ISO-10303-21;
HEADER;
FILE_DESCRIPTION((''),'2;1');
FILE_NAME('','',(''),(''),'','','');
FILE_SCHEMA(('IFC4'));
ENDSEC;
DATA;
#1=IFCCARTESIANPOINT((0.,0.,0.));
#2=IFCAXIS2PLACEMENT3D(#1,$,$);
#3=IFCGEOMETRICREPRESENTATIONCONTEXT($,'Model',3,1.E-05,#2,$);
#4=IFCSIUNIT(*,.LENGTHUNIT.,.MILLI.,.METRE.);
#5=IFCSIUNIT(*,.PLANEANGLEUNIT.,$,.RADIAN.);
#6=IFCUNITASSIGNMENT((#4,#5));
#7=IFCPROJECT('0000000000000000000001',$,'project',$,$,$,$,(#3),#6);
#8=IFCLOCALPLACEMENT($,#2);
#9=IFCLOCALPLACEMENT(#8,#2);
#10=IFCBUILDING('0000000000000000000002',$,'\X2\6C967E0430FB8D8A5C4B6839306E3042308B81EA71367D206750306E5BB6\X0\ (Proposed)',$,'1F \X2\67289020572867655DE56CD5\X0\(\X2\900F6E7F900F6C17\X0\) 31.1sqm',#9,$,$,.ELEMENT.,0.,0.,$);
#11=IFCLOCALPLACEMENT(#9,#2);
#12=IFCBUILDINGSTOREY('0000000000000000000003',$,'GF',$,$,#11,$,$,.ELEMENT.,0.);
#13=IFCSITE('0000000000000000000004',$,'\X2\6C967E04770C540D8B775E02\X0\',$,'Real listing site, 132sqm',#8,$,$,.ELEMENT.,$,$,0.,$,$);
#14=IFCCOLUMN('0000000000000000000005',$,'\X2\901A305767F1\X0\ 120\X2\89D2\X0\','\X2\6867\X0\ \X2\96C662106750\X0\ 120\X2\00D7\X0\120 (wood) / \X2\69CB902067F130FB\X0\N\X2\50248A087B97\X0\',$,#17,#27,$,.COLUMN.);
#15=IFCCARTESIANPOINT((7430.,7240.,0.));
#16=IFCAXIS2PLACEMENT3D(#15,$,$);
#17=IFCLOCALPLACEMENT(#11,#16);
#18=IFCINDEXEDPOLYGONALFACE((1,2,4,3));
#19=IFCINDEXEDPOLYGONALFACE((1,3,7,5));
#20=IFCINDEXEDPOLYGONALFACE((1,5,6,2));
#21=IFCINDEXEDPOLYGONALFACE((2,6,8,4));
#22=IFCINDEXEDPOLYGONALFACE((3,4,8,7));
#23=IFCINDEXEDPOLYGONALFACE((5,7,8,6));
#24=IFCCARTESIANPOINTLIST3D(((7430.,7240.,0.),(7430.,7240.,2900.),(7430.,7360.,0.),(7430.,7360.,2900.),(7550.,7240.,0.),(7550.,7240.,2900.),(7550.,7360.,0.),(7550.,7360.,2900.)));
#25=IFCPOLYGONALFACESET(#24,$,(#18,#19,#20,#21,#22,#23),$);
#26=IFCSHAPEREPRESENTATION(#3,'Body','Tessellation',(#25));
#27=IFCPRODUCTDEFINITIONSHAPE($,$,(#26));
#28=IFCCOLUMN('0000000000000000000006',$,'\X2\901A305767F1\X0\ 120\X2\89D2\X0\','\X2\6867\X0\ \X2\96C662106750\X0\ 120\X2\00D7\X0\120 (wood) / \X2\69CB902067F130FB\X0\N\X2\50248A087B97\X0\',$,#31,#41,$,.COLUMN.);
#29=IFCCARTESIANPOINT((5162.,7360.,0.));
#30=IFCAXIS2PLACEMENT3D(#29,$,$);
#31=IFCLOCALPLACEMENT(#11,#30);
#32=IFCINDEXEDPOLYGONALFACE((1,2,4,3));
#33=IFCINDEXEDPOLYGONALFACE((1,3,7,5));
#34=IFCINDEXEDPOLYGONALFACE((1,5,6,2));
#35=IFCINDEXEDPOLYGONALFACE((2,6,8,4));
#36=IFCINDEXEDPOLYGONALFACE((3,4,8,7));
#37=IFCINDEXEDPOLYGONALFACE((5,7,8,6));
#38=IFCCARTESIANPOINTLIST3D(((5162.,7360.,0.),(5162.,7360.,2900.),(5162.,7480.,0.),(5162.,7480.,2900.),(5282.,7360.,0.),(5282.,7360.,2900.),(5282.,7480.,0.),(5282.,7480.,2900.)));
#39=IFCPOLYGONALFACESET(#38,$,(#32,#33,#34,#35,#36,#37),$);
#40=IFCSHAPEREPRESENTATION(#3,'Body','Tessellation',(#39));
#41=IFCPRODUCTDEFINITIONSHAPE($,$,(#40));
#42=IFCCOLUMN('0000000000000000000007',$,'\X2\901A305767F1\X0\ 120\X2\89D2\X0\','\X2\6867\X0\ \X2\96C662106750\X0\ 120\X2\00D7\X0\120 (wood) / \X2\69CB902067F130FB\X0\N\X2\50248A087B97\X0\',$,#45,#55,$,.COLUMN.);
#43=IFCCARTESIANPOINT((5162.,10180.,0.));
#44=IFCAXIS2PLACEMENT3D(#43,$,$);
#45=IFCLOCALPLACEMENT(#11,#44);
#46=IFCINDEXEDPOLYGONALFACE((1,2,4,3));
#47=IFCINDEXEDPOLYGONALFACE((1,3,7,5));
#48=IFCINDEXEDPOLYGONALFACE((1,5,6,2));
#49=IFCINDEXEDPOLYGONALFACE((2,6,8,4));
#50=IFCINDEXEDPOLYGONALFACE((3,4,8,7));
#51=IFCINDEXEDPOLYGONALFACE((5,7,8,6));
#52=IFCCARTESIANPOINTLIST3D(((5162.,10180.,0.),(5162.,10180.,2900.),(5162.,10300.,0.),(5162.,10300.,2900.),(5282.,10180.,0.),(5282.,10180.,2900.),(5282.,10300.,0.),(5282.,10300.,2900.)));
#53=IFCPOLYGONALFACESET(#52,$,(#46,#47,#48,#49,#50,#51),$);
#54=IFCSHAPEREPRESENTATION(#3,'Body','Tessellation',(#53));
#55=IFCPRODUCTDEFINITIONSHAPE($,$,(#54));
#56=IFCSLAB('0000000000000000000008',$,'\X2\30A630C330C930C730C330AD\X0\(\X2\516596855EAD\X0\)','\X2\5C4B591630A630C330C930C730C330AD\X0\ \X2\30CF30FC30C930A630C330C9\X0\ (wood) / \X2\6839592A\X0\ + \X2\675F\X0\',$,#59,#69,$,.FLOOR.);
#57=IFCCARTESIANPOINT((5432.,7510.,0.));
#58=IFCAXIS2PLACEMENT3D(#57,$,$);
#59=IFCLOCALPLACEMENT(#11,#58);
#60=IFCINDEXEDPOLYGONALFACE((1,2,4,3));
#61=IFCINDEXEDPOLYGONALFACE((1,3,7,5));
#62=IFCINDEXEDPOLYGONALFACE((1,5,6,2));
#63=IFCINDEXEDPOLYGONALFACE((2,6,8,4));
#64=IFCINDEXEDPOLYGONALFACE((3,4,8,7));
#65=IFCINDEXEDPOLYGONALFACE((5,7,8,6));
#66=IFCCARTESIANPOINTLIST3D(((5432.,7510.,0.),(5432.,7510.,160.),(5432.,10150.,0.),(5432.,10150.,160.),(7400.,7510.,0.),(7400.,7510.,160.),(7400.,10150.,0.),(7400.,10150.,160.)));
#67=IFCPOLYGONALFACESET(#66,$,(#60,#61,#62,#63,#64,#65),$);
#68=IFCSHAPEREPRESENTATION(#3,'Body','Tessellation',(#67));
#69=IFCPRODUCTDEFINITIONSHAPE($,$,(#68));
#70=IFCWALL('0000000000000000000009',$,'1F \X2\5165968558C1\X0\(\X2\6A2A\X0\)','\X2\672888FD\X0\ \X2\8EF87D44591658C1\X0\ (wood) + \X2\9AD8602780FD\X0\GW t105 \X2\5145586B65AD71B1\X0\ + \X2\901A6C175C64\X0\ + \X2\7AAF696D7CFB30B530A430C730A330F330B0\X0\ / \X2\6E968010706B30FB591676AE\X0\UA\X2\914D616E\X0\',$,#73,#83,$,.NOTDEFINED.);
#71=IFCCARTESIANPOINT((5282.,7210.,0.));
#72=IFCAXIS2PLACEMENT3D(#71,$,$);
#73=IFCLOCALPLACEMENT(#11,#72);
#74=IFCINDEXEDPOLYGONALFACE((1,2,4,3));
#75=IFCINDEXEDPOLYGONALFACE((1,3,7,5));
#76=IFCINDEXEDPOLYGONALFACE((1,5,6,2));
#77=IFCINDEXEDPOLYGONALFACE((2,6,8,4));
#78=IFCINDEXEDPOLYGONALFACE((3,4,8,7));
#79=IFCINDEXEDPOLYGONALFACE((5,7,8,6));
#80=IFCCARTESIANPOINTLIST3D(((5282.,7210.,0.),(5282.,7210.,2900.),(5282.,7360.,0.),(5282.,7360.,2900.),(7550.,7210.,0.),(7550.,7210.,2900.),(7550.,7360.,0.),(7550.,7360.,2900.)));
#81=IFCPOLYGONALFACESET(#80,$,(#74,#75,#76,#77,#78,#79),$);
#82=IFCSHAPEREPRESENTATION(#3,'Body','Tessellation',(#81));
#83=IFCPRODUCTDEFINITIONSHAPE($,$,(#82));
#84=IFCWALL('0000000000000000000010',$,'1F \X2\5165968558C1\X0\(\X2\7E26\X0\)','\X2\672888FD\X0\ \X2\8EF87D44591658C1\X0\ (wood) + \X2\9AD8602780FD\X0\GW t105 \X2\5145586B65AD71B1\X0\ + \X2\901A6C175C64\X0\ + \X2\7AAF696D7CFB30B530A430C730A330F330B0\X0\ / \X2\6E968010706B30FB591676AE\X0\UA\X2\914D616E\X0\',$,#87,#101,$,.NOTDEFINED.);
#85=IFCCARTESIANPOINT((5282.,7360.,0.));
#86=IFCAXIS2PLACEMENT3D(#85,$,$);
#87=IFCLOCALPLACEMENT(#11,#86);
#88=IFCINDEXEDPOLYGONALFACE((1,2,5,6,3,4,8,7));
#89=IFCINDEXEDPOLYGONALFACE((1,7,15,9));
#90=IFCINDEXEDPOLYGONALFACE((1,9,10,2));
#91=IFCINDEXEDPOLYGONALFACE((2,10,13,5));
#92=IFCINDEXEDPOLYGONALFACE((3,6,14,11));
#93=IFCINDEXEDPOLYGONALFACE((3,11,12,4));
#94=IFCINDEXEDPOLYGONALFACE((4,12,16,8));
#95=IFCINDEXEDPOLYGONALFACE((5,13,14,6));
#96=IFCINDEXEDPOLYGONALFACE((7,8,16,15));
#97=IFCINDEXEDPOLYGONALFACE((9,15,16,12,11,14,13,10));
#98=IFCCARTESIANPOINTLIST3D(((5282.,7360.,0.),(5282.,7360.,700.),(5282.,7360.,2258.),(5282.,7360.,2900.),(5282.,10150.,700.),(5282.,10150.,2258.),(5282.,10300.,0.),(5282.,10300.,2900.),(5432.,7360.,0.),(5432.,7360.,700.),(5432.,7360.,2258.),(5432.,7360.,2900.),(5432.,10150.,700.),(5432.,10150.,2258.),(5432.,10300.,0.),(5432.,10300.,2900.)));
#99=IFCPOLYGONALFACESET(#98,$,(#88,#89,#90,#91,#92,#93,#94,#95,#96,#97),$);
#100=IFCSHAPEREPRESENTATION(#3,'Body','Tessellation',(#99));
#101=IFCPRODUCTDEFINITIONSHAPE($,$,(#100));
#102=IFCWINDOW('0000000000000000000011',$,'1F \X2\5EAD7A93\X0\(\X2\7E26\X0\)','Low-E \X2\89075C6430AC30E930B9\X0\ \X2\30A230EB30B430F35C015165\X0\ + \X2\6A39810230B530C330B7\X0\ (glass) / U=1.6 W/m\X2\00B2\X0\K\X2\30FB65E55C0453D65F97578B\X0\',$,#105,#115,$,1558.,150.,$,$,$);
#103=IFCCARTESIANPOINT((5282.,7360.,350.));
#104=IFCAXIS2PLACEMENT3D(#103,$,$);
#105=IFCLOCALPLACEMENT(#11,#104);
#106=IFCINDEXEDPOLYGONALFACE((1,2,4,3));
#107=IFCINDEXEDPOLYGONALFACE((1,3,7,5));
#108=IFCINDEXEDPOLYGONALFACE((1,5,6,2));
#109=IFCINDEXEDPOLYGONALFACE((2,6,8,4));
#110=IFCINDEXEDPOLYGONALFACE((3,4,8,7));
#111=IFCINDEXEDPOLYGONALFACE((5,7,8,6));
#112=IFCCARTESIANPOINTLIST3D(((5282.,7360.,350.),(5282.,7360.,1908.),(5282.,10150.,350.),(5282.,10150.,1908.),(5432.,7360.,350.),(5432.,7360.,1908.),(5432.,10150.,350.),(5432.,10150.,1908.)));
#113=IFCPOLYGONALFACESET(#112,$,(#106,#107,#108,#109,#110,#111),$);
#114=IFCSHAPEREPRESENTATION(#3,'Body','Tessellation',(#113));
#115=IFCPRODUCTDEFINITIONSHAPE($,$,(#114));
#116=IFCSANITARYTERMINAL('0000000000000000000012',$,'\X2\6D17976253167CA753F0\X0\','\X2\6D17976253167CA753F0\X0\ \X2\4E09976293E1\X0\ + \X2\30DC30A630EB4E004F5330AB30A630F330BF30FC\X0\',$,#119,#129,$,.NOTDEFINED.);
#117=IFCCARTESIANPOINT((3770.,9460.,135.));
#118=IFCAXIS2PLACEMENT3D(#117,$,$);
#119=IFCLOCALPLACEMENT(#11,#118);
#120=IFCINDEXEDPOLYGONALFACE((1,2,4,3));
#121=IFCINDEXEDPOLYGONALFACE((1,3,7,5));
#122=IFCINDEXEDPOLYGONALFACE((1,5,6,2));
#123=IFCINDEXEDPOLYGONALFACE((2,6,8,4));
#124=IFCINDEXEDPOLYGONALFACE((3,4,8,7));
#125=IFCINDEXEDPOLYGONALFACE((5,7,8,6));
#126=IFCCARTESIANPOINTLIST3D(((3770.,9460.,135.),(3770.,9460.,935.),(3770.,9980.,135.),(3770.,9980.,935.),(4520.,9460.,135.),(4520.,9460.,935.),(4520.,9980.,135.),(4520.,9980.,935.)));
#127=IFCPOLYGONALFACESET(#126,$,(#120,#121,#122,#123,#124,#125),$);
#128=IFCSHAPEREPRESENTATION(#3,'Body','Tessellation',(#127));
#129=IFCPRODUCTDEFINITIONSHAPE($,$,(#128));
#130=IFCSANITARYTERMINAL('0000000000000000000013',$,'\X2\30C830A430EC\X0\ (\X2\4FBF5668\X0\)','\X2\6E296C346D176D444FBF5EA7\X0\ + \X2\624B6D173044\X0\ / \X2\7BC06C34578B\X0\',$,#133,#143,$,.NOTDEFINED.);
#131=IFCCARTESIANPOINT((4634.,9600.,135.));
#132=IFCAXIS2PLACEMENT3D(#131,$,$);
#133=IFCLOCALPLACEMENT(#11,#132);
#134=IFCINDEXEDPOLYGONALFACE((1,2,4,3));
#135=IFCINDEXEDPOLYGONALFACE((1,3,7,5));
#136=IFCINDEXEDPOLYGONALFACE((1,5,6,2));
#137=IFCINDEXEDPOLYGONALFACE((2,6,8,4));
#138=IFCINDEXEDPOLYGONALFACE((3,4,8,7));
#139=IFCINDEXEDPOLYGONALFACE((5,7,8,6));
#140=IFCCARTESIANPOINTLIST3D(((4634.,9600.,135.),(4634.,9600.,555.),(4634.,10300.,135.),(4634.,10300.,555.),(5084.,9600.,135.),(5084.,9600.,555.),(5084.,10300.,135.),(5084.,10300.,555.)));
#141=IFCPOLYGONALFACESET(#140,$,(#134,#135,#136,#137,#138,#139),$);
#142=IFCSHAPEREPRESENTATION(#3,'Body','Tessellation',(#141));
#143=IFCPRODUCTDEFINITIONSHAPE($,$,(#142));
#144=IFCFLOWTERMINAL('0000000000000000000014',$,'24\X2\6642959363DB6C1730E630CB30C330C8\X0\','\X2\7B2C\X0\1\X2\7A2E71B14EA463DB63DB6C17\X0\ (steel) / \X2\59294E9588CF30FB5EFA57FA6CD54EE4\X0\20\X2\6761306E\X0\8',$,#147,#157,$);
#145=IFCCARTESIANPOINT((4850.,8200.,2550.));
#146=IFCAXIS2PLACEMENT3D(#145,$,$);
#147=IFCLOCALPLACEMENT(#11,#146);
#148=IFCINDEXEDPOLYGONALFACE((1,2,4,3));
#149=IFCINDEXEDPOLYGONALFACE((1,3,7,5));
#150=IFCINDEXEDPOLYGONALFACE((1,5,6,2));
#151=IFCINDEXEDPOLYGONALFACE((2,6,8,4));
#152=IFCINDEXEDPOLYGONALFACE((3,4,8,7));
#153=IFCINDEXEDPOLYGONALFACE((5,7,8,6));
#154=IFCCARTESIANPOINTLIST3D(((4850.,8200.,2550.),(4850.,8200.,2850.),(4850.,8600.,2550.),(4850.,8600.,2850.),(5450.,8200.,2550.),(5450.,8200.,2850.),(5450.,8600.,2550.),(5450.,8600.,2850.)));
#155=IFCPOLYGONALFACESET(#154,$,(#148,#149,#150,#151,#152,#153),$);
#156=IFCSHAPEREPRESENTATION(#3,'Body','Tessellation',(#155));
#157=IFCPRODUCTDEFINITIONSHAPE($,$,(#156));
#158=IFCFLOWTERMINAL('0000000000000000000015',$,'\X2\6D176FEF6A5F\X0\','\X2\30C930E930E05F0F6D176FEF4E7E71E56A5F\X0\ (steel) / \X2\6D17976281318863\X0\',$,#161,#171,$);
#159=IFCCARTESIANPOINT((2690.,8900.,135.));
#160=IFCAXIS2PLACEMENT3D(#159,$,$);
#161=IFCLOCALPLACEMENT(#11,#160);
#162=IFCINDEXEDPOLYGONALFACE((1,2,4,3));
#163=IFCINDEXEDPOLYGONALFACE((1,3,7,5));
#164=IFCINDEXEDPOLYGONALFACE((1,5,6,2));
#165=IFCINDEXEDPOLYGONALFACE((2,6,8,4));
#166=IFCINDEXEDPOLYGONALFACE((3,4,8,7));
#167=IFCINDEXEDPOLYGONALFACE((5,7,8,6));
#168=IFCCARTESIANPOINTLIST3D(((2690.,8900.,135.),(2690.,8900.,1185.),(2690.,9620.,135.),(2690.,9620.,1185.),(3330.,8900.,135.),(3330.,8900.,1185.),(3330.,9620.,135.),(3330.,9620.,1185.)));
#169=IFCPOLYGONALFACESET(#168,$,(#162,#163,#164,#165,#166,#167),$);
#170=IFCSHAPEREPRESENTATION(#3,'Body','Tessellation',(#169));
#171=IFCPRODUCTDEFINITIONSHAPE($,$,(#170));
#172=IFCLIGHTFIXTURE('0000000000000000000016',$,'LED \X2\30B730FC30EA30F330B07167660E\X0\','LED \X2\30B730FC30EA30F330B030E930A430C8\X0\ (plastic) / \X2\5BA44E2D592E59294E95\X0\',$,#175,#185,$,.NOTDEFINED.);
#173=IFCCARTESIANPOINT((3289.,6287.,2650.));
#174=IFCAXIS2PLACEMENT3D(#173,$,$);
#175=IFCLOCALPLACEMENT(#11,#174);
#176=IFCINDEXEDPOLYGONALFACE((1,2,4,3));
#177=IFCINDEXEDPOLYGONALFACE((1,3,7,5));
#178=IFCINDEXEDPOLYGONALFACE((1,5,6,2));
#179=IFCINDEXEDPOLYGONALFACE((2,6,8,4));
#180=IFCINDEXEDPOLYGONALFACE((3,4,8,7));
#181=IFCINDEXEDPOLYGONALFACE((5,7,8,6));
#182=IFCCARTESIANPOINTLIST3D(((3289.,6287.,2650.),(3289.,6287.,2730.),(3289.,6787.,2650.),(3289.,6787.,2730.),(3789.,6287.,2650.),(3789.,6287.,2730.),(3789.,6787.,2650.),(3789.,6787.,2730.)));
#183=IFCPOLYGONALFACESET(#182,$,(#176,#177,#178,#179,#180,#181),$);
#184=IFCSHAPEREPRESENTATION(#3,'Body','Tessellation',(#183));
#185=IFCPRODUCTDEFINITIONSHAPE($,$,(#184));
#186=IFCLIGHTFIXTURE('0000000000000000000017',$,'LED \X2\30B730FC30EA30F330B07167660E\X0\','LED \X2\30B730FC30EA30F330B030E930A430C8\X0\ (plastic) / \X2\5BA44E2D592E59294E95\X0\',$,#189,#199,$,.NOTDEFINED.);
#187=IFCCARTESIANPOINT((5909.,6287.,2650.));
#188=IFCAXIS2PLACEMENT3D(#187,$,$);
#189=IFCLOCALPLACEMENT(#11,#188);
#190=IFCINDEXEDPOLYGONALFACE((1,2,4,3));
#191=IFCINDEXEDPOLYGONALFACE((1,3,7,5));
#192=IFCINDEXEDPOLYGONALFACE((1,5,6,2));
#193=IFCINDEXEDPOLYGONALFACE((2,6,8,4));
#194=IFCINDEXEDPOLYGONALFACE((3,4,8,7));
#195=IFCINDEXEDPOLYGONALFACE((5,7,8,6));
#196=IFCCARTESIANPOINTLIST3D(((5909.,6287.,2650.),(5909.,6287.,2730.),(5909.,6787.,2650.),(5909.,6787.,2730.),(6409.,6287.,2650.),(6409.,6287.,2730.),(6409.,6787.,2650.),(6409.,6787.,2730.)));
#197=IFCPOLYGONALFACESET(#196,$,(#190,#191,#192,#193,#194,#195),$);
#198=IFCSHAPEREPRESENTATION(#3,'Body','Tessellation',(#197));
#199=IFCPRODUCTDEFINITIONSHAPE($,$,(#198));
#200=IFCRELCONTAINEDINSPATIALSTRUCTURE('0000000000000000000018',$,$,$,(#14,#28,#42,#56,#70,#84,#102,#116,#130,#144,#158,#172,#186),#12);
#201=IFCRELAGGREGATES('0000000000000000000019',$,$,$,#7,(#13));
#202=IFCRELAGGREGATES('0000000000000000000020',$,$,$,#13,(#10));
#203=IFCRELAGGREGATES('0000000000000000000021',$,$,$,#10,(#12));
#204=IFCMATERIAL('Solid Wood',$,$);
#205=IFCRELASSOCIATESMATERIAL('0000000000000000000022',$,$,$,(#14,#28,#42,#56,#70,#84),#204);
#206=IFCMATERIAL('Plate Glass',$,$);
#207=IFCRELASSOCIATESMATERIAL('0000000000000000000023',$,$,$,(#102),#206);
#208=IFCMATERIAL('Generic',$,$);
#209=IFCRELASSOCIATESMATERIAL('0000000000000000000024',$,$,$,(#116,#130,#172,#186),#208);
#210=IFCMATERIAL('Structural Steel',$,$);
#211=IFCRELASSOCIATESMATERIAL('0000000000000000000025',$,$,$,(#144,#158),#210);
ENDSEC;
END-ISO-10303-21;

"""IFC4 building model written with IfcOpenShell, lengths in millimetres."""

from ifc_helpers import new_model, si_unit, frame, frame_2d, origin, place, context, project, spatial, rectangle, extrude, material, element, fill, save


model = new_model("IFC4")

# Units and contexts
model_context = context("Model", 3, precision=1e-05, world=origin())
ifc_project = project(units=[si_unit("LENGTHUNIT", "METRE", prefix="MILLI"), si_unit("PLANEANGLEUNIT", "RADIAN")], contexts=[model_context])

# Site, building, storey
site_placement = place(None, origin())
site = spatial("IfcSite", under=ifc_project, at=site_placement, Name="沖縄県名護市", ObjectType="Real listing site, 132sqm", CompositionType="ELEMENT", RefElevation=0.0)
building_placement = place(site_placement, origin())
building = spatial("IfcBuilding", under=site, at=building_placement, Name="沖縄・越屋根のある自然素材の家 (Proposed)", ObjectType="1F 木造在来工法(透湿透気) 31.1sqm", CompositionType="ELEMENT", ElevationOfRefHeight=0.0, ElevationOfTerrain=0.0)
storey_placement = place(building_placement, origin())
storey = spatial("IfcBuildingStorey", under=building, at=storey_placement, Name="GF", CompositionType="ELEMENT", Elevation=0.0)

# Columns
ifc_material_1 = material(Name="Solid Wood")
column_1_placement = place(storey_placement, frame((7430.0, 7240.0, 0.0)))
element("IfcColumn", 1, at=column_1_placement, inside=storey, material=ifc_material_1, Name="通し柱 120角", Description="桧 集成材 120×120 (wood) / 構造柱・N値計算", PredefinedType="COLUMN", context=model_context, shape_type="SweptSolid", body=[
    extrude(rectangle(XDim=120.0, YDim=120.0, at=frame_2d((60.0, 60.0))), frame((7430.0, 7240.0, 0.0)), (0.0, 0.0, 1.0), 2900.0),
])
column_2_placement = place(storey_placement, frame((5162.0, 7360.0, 0.0)))
element("IfcColumn", 2, at=column_2_placement, inside=storey, material=ifc_material_1, Name="通し柱 120角", Description="桧 集成材 120×120 (wood) / 構造柱・N値計算", PredefinedType="COLUMN", context=model_context, shape_type="SweptSolid", body=[
    extrude(rectangle(XDim=120.0, YDim=120.0, at=frame_2d((60.0, 60.0))), frame((5162.0, 7360.0, 0.0)), (0.0, 0.0, 1.0), 2900.0),
])
column_3_placement = place(storey_placement, frame((5162.0, 10180.0, 0.0)))
element("IfcColumn", 3, at=column_3_placement, inside=storey, material=ifc_material_1, Name="通し柱 120角", Description="桧 集成材 120×120 (wood) / 構造柱・N値計算", PredefinedType="COLUMN", context=model_context, shape_type="SweptSolid", body=[
    extrude(rectangle(XDim=120.0, YDim=120.0, at=frame_2d((60.0, 60.0))), frame((5162.0, 10180.0, 0.0)), (0.0, 0.0, 1.0), 2900.0),
])

# Slab
slab_placement = place(storey_placement, frame((5432.0, 7510.0, 0.0)))
element("IfcSlab", 4, at=slab_placement, inside=storey, material=ifc_material_1, Name="ウッドデッキ(入隅庭)", Description="屋外ウッドデッキ ハードウッド (wood) / 根太 + 束", PredefinedType="FLOOR", context=model_context, shape_type="SweptSolid", body=[
    extrude(rectangle(XDim=1968.0, YDim=2640.0, at=frame_2d((984.0, 1320.0))), frame((5432.0, 7510.0, 0.0)), (0.0, 0.0, 1.0), 160.0),
])

# Wall
wall_1_placement = place(storey_placement, frame((5282.0, 7210.0, 0.0)))
element("IfcWall", 5, at=wall_1_placement, inside=storey, material=ifc_material_1, Name="1F 入隅壁(横)", Description="木製 軸組外壁 (wood) + 高性能GW t105 充填断熱 + 通気層 + 窯業系サイディング / 準耐火・外皮UA配慮", PredefinedType="NOTDEFINED", context=model_context, shape_type="SweptSolid", body=[
    extrude(rectangle(XDim=2268.0, YDim=150.0, at=frame_2d((1134.0, 75.0))), frame((5282.0, 7210.0, 0.0)), (0.0, 0.0, 1.0), 2900.0),
])

# Wall, opening, window
wall_2_placement = place(storey_placement, frame((5282.0, 7360.0, 0.0)))
wall_2 = element("IfcWall", 6, at=wall_2_placement, inside=storey, material=ifc_material_1, Name="1F 入隅壁(縦)", Description="木製 軸組外壁 (wood) + 高性能GW t105 充填断熱 + 通気層 + 窯業系サイディング / 準耐火・外皮UA配慮", PredefinedType="NOTDEFINED", context=model_context, shape_type="SweptSolid", body=[
    extrude(rectangle(XDim=150.0, YDim=2940.0, at=frame_2d((75.0, 1470.0))), frame((5282.0, 7360.0, 0.0)), (0.0, 0.0, 1.0), 2900.0),
])
opening_placement = place(storey_placement, frame((5282.0, 7360.0, 350.0)))
opening = element("IfcOpeningElement", 7, at=opening_placement, cuts=wall_2, PredefinedType="NOTDEFINED", context=model_context, shape_type="SweptSolid", body=[
    extrude(rectangle(XDim=150.0, YDim=2790.0, at=frame_2d((75.0, 1395.0))), frame((5282.0, 7360.0, 350.0)), (0.0, 0.0, 1.0), 1558.0),
])
ifc_material_2 = material(Name="Plate Glass")
window_placement = place(storey_placement, frame((5282.0, 7360.0, 350.0)))
window = element("IfcWindow", 8, at=window_placement, inside=storey, material=ifc_material_2, Name="1F 庭窓(縦)", Description="Low-E 複層ガラス アルゴン封入 + 樹脂サッシ (glass) / U=1.6 W/m²K・日射取得型", OverallHeight=1558.0, OverallWidth=150.0, context=model_context, shape_type="SweptSolid", body=[
    extrude(rectangle(XDim=150.0, YDim=2790.0, at=frame_2d((75.0, 1395.0))), frame((5282.0, 7360.0, 350.0)), (0.0, 0.0, 1.0), 1558.0),
])
fill(opening, window)

# Sanitary terminals
ifc_material_3 = material(Name="Generic")
sanitary_terminal_1_placement = place(storey_placement, frame((3770.0, 9460.0, 135.0)))
element("IfcSanitaryTerminal", 9, at=sanitary_terminal_1_placement, inside=storey, material=ifc_material_3, Name="洗面化粧台", Description="洗面化粧台 三面鏡 + ボウル一体カウンター", PredefinedType="NOTDEFINED", context=model_context, shape_type="SweptSolid", body=[
    extrude(rectangle(XDim=750.0, YDim=520.0, at=frame_2d((375.0, 260.0))), frame((3770.0, 9460.0, 135.0)), (0.0, 0.0, 1.0), 800.0),
])
sanitary_terminal_2_placement = place(storey_placement, frame((4634.0, 9600.0, 135.0)))
element("IfcSanitaryTerminal", 10, at=sanitary_terminal_2_placement, inside=storey, material=ifc_material_3, Name="トイレ (便器)", Description="温水洗浄便座 + 手洗い / 節水型", PredefinedType="NOTDEFINED", context=model_context, shape_type="SweptSolid", body=[
    extrude(rectangle(XDim=450.0, YDim=700.0, at=frame_2d((225.0, 350.0))), frame((4634.0, 9600.0, 135.0)), (0.0, 0.0, 1.0), 420.0),
])

# Flow terminals
ifc_material_4 = material(Name="Structural Steel")
flow_terminal_1_placement = place(storey_placement, frame((4850.0, 8200.0, 2550.0)))
element("IfcFlowTerminal", 11, at=flow_terminal_1_placement, inside=storey, material=ifc_material_4, Name="24時間換気ユニット", Description="第1種熱交換換気 (steel) / 天井裏・建基法令20条の8", context=model_context, shape_type="SweptSolid", body=[
    extrude(rectangle(XDim=600.0, YDim=400.0, at=frame_2d((300.0, 200.0))), frame((4850.0, 8200.0, 2550.0)), (0.0, 0.0, 1.0), 300.0),
])
flow_terminal_2_placement = place(storey_placement, frame((2690.0, 8900.0, 135.0)))
element("IfcFlowTerminal", 12, at=flow_terminal_2_placement, inside=storey, material=ifc_material_4, Name="洗濯機", Description="ドラム式洗濯乾燥機 (steel) / 洗面脱衣", context=model_context, shape_type="SweptSolid", body=[
    extrude(rectangle(XDim=640.0, YDim=720.0, at=frame_2d((320.0, 360.0))), frame((2690.0, 8900.0, 135.0)), (0.0, 0.0, 1.0), 1050.0),
])

# Light fixtures
light_fixture_1_placement = place(storey_placement, frame((3289.0, 6287.0, 2650.0)))
element("IfcLightFixture", 13, at=light_fixture_1_placement, inside=storey, material=ifc_material_3, Name="LED シーリング照明", Description="LED シーリングライト (plastic) / 室中央天井", PredefinedType="NOTDEFINED", context=model_context, shape_type="SweptSolid", body=[
    extrude(rectangle(XDim=500.0, YDim=500.0, at=frame_2d((250.0, 250.0))), frame((3289.0, 6287.0, 2650.0)), (0.0, 0.0, 1.0), 80.0),
])
light_fixture_2_placement = place(storey_placement, frame((5909.0, 6287.0, 2650.0)))
element("IfcLightFixture", 14, at=light_fixture_2_placement, inside=storey, material=ifc_material_3, Name="LED シーリング照明", Description="LED シーリングライト (plastic) / 室中央天井", PredefinedType="NOTDEFINED", context=model_context, shape_type="SweptSolid", body=[
    extrude(rectangle(XDim=500.0, YDim=500.0, at=frame_2d((250.0, 250.0))), frame((5909.0, 6287.0, 2650.0)), (0.0, 0.0, 1.0), 80.0),
])

save(model, "model.ifc")
